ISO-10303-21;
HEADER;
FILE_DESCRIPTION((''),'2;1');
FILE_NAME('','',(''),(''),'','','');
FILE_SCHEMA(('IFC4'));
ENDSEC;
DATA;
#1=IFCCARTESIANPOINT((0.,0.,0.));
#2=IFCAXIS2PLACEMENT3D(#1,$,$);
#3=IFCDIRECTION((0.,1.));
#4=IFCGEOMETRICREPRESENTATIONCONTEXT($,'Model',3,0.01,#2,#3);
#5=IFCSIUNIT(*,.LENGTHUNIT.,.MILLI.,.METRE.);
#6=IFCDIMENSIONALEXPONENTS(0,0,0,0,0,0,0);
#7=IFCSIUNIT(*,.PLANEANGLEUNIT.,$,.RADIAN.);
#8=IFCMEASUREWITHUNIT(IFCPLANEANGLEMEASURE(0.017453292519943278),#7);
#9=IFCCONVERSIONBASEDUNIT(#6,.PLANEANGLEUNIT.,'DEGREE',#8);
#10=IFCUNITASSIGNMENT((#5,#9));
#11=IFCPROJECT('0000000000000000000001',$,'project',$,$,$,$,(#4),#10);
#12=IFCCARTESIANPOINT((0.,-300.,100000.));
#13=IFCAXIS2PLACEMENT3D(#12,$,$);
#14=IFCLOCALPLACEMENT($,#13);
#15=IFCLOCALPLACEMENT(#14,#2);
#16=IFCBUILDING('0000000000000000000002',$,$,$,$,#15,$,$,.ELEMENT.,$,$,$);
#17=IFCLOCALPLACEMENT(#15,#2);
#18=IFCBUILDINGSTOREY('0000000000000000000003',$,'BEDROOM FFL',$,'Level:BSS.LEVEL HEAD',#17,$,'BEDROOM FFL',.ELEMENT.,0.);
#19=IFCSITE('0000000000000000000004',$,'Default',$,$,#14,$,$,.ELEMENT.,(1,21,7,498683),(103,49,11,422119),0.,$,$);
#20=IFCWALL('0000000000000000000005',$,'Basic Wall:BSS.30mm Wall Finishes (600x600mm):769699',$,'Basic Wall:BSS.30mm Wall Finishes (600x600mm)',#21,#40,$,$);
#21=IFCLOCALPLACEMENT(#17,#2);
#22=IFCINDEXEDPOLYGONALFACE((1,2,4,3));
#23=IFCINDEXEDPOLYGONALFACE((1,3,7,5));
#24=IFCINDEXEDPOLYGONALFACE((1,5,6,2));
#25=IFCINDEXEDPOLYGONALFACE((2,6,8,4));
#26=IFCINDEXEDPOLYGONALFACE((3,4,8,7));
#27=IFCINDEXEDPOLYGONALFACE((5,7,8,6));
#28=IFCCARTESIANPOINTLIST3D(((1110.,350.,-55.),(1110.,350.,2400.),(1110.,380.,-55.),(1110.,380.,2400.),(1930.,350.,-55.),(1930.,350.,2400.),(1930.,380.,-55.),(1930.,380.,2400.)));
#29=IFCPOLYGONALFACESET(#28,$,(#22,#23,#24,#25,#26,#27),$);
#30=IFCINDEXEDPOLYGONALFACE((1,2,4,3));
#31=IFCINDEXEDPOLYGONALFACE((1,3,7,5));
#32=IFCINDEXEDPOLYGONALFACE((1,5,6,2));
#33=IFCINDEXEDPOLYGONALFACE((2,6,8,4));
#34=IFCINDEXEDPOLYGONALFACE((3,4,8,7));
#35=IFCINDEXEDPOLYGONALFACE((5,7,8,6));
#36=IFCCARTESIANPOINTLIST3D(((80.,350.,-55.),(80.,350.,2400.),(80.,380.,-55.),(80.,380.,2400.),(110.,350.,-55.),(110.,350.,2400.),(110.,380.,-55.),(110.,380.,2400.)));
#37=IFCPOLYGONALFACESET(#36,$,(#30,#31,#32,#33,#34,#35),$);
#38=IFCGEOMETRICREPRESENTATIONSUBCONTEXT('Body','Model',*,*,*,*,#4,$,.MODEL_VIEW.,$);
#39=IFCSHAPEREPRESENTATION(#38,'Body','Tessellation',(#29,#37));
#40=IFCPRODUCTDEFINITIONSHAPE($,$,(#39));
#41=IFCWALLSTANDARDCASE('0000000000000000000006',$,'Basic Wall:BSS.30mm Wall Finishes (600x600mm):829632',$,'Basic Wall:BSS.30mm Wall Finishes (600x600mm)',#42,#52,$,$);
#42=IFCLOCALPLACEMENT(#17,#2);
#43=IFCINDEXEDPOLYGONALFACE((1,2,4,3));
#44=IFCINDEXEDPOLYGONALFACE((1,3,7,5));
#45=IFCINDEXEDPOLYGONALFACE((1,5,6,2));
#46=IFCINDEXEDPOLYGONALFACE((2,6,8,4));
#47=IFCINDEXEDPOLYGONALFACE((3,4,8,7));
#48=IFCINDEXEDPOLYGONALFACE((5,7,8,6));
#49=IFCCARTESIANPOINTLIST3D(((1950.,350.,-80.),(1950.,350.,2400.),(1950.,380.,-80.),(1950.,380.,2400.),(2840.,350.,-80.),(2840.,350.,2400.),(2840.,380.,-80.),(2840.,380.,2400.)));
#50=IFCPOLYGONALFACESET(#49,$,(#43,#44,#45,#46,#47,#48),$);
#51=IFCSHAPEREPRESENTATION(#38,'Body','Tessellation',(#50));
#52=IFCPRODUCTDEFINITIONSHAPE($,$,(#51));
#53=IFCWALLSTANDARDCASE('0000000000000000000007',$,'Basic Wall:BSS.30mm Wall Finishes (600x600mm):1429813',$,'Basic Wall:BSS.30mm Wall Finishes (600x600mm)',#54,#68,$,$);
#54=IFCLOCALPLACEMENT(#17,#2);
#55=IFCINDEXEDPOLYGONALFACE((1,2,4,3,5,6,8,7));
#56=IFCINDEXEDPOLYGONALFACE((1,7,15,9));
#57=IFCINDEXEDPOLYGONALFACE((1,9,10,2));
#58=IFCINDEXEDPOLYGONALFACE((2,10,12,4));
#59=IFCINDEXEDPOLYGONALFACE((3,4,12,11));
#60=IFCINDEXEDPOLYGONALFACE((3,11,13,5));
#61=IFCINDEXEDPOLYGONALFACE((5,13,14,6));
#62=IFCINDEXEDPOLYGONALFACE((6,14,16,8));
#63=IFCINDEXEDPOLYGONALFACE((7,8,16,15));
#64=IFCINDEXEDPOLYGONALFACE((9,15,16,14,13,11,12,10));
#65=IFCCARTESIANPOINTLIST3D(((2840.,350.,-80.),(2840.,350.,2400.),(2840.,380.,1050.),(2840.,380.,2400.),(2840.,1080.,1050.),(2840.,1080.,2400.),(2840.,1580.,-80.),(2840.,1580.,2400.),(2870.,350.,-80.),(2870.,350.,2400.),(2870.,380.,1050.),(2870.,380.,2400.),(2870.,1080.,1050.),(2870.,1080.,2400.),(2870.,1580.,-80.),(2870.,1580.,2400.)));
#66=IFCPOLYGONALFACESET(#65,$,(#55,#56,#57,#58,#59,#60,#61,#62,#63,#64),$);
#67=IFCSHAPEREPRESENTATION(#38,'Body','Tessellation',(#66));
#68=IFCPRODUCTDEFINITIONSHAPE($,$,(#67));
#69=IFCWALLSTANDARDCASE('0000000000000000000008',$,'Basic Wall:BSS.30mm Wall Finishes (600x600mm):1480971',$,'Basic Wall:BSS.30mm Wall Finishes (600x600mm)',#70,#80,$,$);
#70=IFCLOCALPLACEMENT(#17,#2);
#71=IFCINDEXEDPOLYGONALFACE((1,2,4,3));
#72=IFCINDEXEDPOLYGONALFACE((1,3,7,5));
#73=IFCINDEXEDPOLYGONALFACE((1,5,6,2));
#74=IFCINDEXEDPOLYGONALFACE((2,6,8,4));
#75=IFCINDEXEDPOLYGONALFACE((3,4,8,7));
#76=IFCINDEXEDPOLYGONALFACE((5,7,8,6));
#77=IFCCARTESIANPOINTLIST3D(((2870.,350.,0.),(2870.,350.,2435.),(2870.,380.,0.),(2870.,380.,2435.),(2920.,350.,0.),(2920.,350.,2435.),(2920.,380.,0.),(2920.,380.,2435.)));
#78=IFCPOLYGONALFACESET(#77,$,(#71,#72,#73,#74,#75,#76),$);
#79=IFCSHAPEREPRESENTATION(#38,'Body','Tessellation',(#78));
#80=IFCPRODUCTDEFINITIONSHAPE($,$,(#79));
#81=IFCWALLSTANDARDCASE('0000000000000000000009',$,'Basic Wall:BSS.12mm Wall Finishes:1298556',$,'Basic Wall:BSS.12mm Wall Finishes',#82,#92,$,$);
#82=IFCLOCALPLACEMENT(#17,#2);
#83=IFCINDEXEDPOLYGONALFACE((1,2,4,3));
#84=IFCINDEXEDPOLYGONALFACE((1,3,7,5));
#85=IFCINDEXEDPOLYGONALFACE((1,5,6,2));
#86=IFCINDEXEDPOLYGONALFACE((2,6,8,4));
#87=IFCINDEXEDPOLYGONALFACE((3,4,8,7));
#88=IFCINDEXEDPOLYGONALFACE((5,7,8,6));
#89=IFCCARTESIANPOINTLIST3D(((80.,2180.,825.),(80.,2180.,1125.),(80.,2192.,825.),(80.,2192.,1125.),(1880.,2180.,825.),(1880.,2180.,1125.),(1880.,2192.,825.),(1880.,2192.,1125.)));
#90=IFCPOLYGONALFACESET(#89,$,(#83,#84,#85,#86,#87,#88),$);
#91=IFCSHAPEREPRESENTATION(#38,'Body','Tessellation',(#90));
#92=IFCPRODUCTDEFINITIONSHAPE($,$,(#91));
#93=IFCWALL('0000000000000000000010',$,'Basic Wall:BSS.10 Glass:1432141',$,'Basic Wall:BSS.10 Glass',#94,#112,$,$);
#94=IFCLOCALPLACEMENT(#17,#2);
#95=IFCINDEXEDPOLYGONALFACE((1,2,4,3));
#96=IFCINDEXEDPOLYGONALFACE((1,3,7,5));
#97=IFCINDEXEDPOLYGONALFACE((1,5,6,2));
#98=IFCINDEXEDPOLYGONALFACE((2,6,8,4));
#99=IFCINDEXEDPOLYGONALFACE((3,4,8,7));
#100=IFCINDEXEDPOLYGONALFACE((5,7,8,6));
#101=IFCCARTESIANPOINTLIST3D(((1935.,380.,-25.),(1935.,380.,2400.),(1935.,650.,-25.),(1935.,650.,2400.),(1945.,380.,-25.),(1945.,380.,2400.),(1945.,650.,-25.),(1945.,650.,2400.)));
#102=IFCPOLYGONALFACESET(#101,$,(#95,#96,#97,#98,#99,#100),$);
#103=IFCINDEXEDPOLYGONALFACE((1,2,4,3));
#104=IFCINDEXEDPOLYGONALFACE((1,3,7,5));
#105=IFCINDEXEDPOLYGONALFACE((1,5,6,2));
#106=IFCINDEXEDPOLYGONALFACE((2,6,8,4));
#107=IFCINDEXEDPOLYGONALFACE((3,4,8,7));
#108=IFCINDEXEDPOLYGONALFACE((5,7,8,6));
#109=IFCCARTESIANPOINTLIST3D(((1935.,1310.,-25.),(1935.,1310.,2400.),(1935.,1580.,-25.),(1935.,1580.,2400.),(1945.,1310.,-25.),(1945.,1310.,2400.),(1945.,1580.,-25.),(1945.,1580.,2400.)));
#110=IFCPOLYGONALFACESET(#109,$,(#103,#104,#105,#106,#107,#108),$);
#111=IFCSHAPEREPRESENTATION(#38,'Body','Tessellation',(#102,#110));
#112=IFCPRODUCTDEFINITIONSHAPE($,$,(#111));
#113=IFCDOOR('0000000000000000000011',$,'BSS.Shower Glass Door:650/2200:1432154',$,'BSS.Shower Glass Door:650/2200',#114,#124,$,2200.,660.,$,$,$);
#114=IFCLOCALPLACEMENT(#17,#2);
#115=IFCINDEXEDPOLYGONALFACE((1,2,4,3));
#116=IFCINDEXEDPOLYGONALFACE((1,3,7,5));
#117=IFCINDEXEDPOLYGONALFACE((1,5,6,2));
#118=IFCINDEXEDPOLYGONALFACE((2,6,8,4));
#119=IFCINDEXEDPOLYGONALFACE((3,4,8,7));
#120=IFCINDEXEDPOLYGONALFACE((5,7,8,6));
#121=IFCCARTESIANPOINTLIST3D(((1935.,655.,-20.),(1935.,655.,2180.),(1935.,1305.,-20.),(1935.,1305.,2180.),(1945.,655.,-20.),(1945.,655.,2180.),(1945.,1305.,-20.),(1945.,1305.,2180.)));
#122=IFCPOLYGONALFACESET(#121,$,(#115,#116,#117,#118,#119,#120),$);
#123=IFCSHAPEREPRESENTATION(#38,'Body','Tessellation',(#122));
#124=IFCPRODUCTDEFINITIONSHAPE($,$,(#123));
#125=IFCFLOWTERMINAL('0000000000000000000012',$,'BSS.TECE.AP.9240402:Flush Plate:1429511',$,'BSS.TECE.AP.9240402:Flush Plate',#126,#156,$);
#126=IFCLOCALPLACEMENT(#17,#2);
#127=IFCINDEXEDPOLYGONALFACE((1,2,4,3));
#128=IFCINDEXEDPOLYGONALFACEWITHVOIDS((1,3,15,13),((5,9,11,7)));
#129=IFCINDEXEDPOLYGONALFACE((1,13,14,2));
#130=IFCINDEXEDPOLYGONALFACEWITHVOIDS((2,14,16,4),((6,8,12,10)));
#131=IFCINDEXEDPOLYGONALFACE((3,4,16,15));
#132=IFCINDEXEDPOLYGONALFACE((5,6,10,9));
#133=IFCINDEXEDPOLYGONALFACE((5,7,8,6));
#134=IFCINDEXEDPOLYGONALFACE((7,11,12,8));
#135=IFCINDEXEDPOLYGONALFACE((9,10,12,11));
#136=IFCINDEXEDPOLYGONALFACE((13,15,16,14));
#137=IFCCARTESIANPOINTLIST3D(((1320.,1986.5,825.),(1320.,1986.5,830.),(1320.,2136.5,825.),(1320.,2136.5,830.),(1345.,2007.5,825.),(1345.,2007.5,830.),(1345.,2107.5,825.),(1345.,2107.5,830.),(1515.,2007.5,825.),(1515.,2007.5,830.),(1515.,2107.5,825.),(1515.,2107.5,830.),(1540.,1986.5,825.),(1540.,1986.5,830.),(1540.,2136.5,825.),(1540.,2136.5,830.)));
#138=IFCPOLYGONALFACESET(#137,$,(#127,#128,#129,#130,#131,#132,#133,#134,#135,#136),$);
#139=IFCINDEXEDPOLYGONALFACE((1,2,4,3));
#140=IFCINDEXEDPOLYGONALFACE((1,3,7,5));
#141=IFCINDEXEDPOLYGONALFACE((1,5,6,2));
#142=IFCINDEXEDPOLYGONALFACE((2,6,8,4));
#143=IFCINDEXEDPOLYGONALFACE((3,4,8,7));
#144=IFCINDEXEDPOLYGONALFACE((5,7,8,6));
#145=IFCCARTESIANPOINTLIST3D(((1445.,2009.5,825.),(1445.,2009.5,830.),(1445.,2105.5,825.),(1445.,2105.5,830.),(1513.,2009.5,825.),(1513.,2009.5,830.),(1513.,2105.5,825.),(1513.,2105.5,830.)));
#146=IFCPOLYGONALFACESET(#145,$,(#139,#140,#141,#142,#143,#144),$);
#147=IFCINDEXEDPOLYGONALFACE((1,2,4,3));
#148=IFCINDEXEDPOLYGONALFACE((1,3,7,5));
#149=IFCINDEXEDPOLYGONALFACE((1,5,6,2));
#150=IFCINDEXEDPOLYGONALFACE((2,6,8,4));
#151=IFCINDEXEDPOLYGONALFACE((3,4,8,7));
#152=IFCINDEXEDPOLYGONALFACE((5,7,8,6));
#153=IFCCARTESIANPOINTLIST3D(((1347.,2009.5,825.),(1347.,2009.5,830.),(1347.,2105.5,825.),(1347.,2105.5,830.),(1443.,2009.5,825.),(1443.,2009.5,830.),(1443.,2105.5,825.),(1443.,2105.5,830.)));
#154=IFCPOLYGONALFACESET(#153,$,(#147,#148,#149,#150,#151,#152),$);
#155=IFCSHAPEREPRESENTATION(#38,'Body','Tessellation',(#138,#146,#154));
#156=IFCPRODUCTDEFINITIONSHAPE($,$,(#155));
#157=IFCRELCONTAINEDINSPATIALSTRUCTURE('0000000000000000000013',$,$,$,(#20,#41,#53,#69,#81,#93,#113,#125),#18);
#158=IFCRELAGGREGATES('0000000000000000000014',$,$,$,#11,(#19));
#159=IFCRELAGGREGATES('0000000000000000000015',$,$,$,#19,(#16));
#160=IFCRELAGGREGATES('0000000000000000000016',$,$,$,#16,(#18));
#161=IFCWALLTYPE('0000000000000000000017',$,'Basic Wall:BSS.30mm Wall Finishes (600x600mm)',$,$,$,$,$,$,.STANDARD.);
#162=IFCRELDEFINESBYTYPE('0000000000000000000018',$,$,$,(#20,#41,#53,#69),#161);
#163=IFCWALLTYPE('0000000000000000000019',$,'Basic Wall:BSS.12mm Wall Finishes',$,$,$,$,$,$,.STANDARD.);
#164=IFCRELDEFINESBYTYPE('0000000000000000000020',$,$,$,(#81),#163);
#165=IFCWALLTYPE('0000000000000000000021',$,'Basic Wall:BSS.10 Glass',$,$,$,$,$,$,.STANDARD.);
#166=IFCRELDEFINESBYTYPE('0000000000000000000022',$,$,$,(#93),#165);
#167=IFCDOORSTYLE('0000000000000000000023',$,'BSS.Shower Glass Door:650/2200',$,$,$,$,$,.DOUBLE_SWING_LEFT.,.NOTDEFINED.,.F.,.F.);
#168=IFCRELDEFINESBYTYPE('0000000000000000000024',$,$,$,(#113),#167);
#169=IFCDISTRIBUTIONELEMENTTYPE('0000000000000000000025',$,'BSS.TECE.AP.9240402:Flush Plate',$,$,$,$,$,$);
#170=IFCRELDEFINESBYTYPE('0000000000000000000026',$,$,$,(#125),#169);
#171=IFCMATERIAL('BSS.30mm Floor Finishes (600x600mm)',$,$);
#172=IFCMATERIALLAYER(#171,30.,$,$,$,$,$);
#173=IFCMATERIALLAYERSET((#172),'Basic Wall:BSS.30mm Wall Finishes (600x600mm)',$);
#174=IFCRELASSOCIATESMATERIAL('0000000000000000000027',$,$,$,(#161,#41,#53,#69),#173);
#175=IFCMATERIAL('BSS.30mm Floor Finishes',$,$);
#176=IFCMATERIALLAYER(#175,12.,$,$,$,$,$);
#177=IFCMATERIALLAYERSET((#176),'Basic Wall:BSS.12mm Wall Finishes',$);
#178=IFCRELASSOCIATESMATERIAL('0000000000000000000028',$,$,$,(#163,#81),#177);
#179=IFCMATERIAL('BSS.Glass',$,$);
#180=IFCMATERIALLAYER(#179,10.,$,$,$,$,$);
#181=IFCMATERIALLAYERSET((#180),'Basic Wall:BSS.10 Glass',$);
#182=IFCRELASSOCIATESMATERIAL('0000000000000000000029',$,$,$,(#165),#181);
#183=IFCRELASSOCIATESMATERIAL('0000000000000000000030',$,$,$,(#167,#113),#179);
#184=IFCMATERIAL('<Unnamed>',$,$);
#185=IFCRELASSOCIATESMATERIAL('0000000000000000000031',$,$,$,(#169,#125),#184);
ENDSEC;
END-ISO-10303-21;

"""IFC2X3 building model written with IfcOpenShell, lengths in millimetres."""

from ifc_helpers import new_model, entity, si_unit, converted_unit, direction, frame, frame_2d, origin, origin_2d_with_axis, place, context, subcontext, project, spatial, polyline, rectangle, outline, extrude, clip, halfspace, source, transform, mapped, material, layer, layer_set, layer_usage, type_object, type_shapes, element, fill, save


model = new_model("IFC2X3")

# Units and contexts
model_context = context("Model", 3, precision=0.01, world=origin(), true_north=direction((0.0, 1.0)))
body_context = subcontext(model_context, "Body", "Model", "MODEL_VIEW")
ifc_project = project(units=[si_unit("LENGTHUNIT", "METRE", prefix="MILLI"), converted_unit("PLANEANGLEUNIT", "DEGREE", entity("IfcPlaneAngleMeasure", 0.017453292519943278), si_unit("PLANEANGLEUNIT", "RADIAN"), dimensions=[0, 0, 0, 0, 0, 0, 0])], contexts=[model_context])

# Site, building, storey
site_placement = place(None, frame((0.0, -300.0, 100000.0)))
site = spatial("IfcSite", under=ifc_project, at=site_placement, Name="Default", CompositionType="ELEMENT", RefLatitude=(1, 21, 7, 498683), RefLongitude=(103, 49, 11, 422119), RefElevation=0.0)
building_placement = place(site_placement, origin())
building = spatial("IfcBuilding", under=site, at=building_placement, CompositionType="ELEMENT")
storey_placement = place(building_placement, origin())
storey = spatial("IfcBuildingStorey", under=building, at=storey_placement, Name="BEDROOM FFL", ObjectType="Level:BSS.LEVEL HEAD", LongName="BEDROOM FFL", CompositionType="ELEMENT", Elevation=0.0)

# Shared definitions
ifc_material_1 = material(Name="BSS.30mm Floor Finishes (600x600mm)")

# Shared definitions
ifc_layer_1 = layer(ifc_material_1, 30.0)
ifc_layer_set_1 = layer_set([ifc_layer_1], Name="Basic Wall:BSS.30mm Wall Finishes (600x600mm)")
wall_type_1 = type_object("IfcWallType", Name="Basic Wall:BSS.30mm Wall Finishes (600x600mm)", PredefinedType="STANDARD", material=ifc_layer_set_1)

# Walls
wall_1_placement = place(storey_placement, frame((1930.0, 365.0, -55.0), z_axis=(0.0, 0.0, 1.0), x_axis=(-1.0, 0.0, 0.0)))
element("IfcWall", 1, at=wall_1_placement, inside=storey, type_object=wall_type_1, Name="Basic Wall:BSS.30mm Wall Finishes (600x600mm):769699", ObjectType="Basic Wall:BSS.30mm Wall Finishes (600x600mm)", context=body_context, shape_type="SweptSolid", body=[
    extrude(rectangle(XDim=820.0, YDim=30.0, at=frame_2d((0.0, 0.0), x_axis=(1.0, 0.0))), frame((410.0, 0.0, 0.0)), (0.0, 0.0, 1.0), 2455.0),
    extrude(rectangle(XDim=30.0, YDim=30.0, at=frame_2d((0.0, 0.0), x_axis=(1.0, 0.0))), frame((1835.0, 0.0, 0.0), z_axis=(0.0, 0.0, 1.0), x_axis=(-1.0, 0.0, 0.0)), (0.0, 0.0, 1.0), 2455.0),
])
ifc_layer_usage_1 = layer_usage(ifc_layer_set_1, "AXIS2", "NEGATIVE", 15.0)
wall_2_placement = place(storey_placement, frame((1950.0, 365.0, -80.0)))
element("IfcWallStandardCase", 2, at=wall_2_placement, inside=storey, type_object=wall_type_1, material=ifc_layer_usage_1, Name="Basic Wall:BSS.30mm Wall Finishes (600x600mm):829632", ObjectType="Basic Wall:BSS.30mm Wall Finishes (600x600mm)", context=body_context, shape_type="SweptSolid", body=[
    extrude(rectangle(XDim=890.0, YDim=30.0, at=frame_2d((445.0, 0.0), x_axis=(-1.0, 0.0))), origin(), (0.0, 0.0, 1.0), 2480.0),
])

# Wall, opening
ifc_layer_usage_2 = layer_usage(ifc_layer_set_1, "AXIS2", "NEGATIVE", 15.0)
wall_3_placement = place(storey_placement, frame((2855.0, 1580.0, -80.0), z_axis=(0.0, 0.0, 1.0), x_axis=(0.0, -1.0, 0.0)))
wall_3 = element("IfcWallStandardCase", 3, at=wall_3_placement, inside=storey, type_object=wall_type_1, material=ifc_layer_usage_2, Name="Basic Wall:BSS.30mm Wall Finishes (600x600mm):1429813", ObjectType="Basic Wall:BSS.30mm Wall Finishes (600x600mm)", context=body_context, shape_type="SweptSolid", body=[
    extrude(rectangle(XDim=1230.0, YDim=30.0, at=frame_2d((615.0, 0.0), x_axis=(-1.0, 0.0))), origin(), (0.0, 0.0, 1.0), 2480.0),
])
opening_1_placement = place(wall_3_placement, frame((1580.0, -2855.0, 80.0), z_axis=(0.0, 0.0, 1.0), x_axis=(0.0, 1.0, 0.0)))
element("IfcOpeningElement", 4, at=opening_1_placement, cuts=wall_3, ObjectType="Opening", context=body_context, shape_type="SweptSolid", body=[
    extrude(rectangle(XDim=1350.0, YDim=700.0, at=origin_2d_with_axis()), frame((1346.0, 730.0, 1725.0), z_axis=(1.0, 0.0, 0.0), x_axis=(0.0, 0.0, -1.0)), (0.0, 0.0, 1.0), 3048.0),
])

# Walls
ifc_layer_usage_3 = layer_usage(ifc_layer_set_1, "AXIS2", "NEGATIVE", 15.0)
wall_4_placement = place(storey_placement, frame((2870.0, 365.0, 0.0)))
element("IfcWallStandardCase", 5, at=wall_4_placement, inside=storey, type_object=wall_type_1, material=ifc_layer_usage_3, Name="Basic Wall:BSS.30mm Wall Finishes (600x600mm):1480971", ObjectType="Basic Wall:BSS.30mm Wall Finishes (600x600mm)", context=body_context, shape_type="SweptSolid", body=[
    extrude(rectangle(XDim=50.0, YDim=30.0, at=frame_2d((25.0, 0.0), x_axis=(-1.0, 0.0))), origin(), (0.0, 0.0, 1.0), 2435.0),
])
ifc_material_2 = material(Name="BSS.30mm Floor Finishes")
ifc_layer_2 = layer(ifc_material_2, 12.0)
ifc_layer_set_2 = layer_set([ifc_layer_2], Name="Basic Wall:BSS.12mm Wall Finishes")
ifc_layer_usage_4 = layer_usage(ifc_layer_set_2, "AXIS2", "NEGATIVE", 6.0)
wall_type_2 = type_object("IfcWallType", Name="Basic Wall:BSS.12mm Wall Finishes", PredefinedType="STANDARD", material=ifc_layer_set_2)
wall_5_placement = place(storey_placement, frame((80.0, 2186.0, 825.0)))
element("IfcWallStandardCase", 6, at=wall_5_placement, inside=storey, type_object=wall_type_2, material=ifc_layer_usage_4, Name="Basic Wall:BSS.12mm Wall Finishes:1298556", ObjectType="Basic Wall:BSS.12mm Wall Finishes", context=body_context, shape_type="Clipping", body=[
    clip(extrude(rectangle(XDim=1800.0, YDim=12.0, at=frame_2d((900.0, 0.0), x_axis=(-1.0, 0.0))), origin(), (0.0, 0.0, 1.0), 300.0), halfspace(frame((0.0, -6.0, 300.0), z_axis=(0.0, 0.0, 1.0), x_axis=(0.0, 1.0, 0.0)), False)),
])

# Wall, opening, door
ifc_material_3 = material(Name="BSS.Glass")
ifc_layer_3 = layer(ifc_material_3, 10.0)
ifc_layer_set_3 = layer_set([ifc_layer_3], Name="Basic Wall:BSS.10 Glass")
wall_type_3 = type_object("IfcWallType", Name="Basic Wall:BSS.10 Glass", PredefinedType="STANDARD", material=ifc_layer_set_3)
wall_6_placement = place(storey_placement, frame((1940.0, 380.0, -25.0), z_axis=(0.0, 0.0, 1.0), x_axis=(0.0, 1.0, 0.0)))
wall_6 = element("IfcWall", 7, at=wall_6_placement, inside=storey, type_object=wall_type_3, Name="Basic Wall:BSS.10 Glass:1432141", ObjectType="Basic Wall:BSS.10 Glass", context=body_context, shape_type="SweptSolid", body=[
    extrude(rectangle(XDim=270.0, YDim=10.0, at=frame_2d((0.0, 0.0), x_axis=(1.0, 0.0))), frame((135.0, 0.0, 0.0)), (0.0, 0.0, 1.0), 2425.0),
    extrude(rectangle(XDim=270.0, YDim=10.0, at=origin_2d_with_axis()), frame((1065.0, 0.0, 0.0), z_axis=(0.0, 0.0, 1.0), x_axis=(-1.0, 0.0, 0.0)), (0.0, 0.0, 1.0), 2425.0),
])
opening_2_placement = place(wall_6_placement, frame((270.0, -5.0, 5.0)))
opening_2 = element("IfcOpeningElement", 8, at=opening_2_placement, cuts=wall_6, ObjectType="Opening", context=body_context, shape_type="SweptSolid", body=[
    extrude(rectangle(XDim=660.0, YDim=2200.0, at=frame_2d((1100.0, 330.0), x_axis=(0.0, -1.0))), frame((0.0, 0.0, 0.0), z_axis=(0.0, 1.0, 0.0), x_axis=(0.0, 0.0, 1.0)), (0.0, 0.0, 1.0), 10.0),
])
door_style = type_object("IfcDoorStyle", Name="BSS.Shower Glass Door:650/2200", ConstructionType="NOTDEFINED", OperationType="DOUBLE_SWING_LEFT", ParameterTakesPrecedence=False, Sizeable=False, material=ifc_material_3)
shared_shape_1 = source(origin(), body_context, "Body", "SweptSolid", [
    extrude(rectangle(XDim=10.0, YDim=650.0, at=origin_2d_with_axis()), frame((330.0, 5.0, 0.0), z_axis=(0.0, 0.0, 1.0), x_axis=(0.0, -1.0, 0.0)), (0.0, 0.0, 1.0), 2200.0),
])
type_shapes(door_style, [shared_shape_1])
door_placement = place(opening_2_placement, origin())
door = element("IfcDoor", 9, at=door_placement, inside=storey, type_object=door_style, material=ifc_material_3, Name="BSS.Shower Glass Door:650/2200:1432154", ObjectType="BSS.Shower Glass Door:650/2200", OverallHeight=2200.0, OverallWidth=660.0, context=body_context, shape_type="MappedRepresentation", body=[
    mapped(shared_shape_1, transform((0.0, 0.0, 0.0), scale=1.0)),
])
fill(opening_2, door)

# Flow terminal
ifc_material_4 = material(Name="<Unnamed>")
distribution_element_type = type_object("IfcDistributionElementType", Name="BSS.TECE.AP.9240402:Flush Plate", material=ifc_material_4)
shared_shape_2 = source(origin(), body_context, "Body", "SweptSolid", [
    extrude(outline(polyline([(-110.0, -75.0), (110.0, -75.0), (110.0, 75.0), (-110.0, 75.0), (-110.0, -75.0)]), holes=[polyline([(-85.0, -46.0), (-85.0, 54.0), (85.0, 54.0), (85.0, -46.0), (-85.0, -46.0)])]), frame((0.0, 0.0, 0.0), z_axis=(0.0, 0.0, 1.0), x_axis=(-1.0, 0.0, 0.0)), (0.0, 0.0, 1.0), 5.0),
    extrude(rectangle(XDim=68.0, YDim=96.0, at=frame_2d((0.0, 0.0), x_axis=(1.0, 0.0))), frame((49.0, -4.0, 0.0)), (0.0, 0.0, 1.0), 5.0),
    extrude(rectangle(XDim=96.0, YDim=96.0, at=frame_2d((0.0, 0.0), x_axis=(1.0, 0.0))), frame((-35.0, -4.0, 0.0)), (0.0, 0.0, 1.0), 5.0),
])
type_shapes(distribution_element_type, [shared_shape_2])
flow_terminal_placement = place(storey_placement, frame((1430.0, 2061.5, 825.0)))
element("IfcFlowTerminal", 10, at=flow_terminal_placement, inside=storey, type_object=distribution_element_type, material=ifc_material_4, Name="BSS.TECE.AP.9240402:Flush Plate:1429511", ObjectType="BSS.TECE.AP.9240402:Flush Plate", context=body_context, shape_type="MappedRepresentation", body=[
    mapped(shared_shape_2, transform((0.0, 0.0, 0.0), scale=1.0)),
])

save(model, "model.ifc")
